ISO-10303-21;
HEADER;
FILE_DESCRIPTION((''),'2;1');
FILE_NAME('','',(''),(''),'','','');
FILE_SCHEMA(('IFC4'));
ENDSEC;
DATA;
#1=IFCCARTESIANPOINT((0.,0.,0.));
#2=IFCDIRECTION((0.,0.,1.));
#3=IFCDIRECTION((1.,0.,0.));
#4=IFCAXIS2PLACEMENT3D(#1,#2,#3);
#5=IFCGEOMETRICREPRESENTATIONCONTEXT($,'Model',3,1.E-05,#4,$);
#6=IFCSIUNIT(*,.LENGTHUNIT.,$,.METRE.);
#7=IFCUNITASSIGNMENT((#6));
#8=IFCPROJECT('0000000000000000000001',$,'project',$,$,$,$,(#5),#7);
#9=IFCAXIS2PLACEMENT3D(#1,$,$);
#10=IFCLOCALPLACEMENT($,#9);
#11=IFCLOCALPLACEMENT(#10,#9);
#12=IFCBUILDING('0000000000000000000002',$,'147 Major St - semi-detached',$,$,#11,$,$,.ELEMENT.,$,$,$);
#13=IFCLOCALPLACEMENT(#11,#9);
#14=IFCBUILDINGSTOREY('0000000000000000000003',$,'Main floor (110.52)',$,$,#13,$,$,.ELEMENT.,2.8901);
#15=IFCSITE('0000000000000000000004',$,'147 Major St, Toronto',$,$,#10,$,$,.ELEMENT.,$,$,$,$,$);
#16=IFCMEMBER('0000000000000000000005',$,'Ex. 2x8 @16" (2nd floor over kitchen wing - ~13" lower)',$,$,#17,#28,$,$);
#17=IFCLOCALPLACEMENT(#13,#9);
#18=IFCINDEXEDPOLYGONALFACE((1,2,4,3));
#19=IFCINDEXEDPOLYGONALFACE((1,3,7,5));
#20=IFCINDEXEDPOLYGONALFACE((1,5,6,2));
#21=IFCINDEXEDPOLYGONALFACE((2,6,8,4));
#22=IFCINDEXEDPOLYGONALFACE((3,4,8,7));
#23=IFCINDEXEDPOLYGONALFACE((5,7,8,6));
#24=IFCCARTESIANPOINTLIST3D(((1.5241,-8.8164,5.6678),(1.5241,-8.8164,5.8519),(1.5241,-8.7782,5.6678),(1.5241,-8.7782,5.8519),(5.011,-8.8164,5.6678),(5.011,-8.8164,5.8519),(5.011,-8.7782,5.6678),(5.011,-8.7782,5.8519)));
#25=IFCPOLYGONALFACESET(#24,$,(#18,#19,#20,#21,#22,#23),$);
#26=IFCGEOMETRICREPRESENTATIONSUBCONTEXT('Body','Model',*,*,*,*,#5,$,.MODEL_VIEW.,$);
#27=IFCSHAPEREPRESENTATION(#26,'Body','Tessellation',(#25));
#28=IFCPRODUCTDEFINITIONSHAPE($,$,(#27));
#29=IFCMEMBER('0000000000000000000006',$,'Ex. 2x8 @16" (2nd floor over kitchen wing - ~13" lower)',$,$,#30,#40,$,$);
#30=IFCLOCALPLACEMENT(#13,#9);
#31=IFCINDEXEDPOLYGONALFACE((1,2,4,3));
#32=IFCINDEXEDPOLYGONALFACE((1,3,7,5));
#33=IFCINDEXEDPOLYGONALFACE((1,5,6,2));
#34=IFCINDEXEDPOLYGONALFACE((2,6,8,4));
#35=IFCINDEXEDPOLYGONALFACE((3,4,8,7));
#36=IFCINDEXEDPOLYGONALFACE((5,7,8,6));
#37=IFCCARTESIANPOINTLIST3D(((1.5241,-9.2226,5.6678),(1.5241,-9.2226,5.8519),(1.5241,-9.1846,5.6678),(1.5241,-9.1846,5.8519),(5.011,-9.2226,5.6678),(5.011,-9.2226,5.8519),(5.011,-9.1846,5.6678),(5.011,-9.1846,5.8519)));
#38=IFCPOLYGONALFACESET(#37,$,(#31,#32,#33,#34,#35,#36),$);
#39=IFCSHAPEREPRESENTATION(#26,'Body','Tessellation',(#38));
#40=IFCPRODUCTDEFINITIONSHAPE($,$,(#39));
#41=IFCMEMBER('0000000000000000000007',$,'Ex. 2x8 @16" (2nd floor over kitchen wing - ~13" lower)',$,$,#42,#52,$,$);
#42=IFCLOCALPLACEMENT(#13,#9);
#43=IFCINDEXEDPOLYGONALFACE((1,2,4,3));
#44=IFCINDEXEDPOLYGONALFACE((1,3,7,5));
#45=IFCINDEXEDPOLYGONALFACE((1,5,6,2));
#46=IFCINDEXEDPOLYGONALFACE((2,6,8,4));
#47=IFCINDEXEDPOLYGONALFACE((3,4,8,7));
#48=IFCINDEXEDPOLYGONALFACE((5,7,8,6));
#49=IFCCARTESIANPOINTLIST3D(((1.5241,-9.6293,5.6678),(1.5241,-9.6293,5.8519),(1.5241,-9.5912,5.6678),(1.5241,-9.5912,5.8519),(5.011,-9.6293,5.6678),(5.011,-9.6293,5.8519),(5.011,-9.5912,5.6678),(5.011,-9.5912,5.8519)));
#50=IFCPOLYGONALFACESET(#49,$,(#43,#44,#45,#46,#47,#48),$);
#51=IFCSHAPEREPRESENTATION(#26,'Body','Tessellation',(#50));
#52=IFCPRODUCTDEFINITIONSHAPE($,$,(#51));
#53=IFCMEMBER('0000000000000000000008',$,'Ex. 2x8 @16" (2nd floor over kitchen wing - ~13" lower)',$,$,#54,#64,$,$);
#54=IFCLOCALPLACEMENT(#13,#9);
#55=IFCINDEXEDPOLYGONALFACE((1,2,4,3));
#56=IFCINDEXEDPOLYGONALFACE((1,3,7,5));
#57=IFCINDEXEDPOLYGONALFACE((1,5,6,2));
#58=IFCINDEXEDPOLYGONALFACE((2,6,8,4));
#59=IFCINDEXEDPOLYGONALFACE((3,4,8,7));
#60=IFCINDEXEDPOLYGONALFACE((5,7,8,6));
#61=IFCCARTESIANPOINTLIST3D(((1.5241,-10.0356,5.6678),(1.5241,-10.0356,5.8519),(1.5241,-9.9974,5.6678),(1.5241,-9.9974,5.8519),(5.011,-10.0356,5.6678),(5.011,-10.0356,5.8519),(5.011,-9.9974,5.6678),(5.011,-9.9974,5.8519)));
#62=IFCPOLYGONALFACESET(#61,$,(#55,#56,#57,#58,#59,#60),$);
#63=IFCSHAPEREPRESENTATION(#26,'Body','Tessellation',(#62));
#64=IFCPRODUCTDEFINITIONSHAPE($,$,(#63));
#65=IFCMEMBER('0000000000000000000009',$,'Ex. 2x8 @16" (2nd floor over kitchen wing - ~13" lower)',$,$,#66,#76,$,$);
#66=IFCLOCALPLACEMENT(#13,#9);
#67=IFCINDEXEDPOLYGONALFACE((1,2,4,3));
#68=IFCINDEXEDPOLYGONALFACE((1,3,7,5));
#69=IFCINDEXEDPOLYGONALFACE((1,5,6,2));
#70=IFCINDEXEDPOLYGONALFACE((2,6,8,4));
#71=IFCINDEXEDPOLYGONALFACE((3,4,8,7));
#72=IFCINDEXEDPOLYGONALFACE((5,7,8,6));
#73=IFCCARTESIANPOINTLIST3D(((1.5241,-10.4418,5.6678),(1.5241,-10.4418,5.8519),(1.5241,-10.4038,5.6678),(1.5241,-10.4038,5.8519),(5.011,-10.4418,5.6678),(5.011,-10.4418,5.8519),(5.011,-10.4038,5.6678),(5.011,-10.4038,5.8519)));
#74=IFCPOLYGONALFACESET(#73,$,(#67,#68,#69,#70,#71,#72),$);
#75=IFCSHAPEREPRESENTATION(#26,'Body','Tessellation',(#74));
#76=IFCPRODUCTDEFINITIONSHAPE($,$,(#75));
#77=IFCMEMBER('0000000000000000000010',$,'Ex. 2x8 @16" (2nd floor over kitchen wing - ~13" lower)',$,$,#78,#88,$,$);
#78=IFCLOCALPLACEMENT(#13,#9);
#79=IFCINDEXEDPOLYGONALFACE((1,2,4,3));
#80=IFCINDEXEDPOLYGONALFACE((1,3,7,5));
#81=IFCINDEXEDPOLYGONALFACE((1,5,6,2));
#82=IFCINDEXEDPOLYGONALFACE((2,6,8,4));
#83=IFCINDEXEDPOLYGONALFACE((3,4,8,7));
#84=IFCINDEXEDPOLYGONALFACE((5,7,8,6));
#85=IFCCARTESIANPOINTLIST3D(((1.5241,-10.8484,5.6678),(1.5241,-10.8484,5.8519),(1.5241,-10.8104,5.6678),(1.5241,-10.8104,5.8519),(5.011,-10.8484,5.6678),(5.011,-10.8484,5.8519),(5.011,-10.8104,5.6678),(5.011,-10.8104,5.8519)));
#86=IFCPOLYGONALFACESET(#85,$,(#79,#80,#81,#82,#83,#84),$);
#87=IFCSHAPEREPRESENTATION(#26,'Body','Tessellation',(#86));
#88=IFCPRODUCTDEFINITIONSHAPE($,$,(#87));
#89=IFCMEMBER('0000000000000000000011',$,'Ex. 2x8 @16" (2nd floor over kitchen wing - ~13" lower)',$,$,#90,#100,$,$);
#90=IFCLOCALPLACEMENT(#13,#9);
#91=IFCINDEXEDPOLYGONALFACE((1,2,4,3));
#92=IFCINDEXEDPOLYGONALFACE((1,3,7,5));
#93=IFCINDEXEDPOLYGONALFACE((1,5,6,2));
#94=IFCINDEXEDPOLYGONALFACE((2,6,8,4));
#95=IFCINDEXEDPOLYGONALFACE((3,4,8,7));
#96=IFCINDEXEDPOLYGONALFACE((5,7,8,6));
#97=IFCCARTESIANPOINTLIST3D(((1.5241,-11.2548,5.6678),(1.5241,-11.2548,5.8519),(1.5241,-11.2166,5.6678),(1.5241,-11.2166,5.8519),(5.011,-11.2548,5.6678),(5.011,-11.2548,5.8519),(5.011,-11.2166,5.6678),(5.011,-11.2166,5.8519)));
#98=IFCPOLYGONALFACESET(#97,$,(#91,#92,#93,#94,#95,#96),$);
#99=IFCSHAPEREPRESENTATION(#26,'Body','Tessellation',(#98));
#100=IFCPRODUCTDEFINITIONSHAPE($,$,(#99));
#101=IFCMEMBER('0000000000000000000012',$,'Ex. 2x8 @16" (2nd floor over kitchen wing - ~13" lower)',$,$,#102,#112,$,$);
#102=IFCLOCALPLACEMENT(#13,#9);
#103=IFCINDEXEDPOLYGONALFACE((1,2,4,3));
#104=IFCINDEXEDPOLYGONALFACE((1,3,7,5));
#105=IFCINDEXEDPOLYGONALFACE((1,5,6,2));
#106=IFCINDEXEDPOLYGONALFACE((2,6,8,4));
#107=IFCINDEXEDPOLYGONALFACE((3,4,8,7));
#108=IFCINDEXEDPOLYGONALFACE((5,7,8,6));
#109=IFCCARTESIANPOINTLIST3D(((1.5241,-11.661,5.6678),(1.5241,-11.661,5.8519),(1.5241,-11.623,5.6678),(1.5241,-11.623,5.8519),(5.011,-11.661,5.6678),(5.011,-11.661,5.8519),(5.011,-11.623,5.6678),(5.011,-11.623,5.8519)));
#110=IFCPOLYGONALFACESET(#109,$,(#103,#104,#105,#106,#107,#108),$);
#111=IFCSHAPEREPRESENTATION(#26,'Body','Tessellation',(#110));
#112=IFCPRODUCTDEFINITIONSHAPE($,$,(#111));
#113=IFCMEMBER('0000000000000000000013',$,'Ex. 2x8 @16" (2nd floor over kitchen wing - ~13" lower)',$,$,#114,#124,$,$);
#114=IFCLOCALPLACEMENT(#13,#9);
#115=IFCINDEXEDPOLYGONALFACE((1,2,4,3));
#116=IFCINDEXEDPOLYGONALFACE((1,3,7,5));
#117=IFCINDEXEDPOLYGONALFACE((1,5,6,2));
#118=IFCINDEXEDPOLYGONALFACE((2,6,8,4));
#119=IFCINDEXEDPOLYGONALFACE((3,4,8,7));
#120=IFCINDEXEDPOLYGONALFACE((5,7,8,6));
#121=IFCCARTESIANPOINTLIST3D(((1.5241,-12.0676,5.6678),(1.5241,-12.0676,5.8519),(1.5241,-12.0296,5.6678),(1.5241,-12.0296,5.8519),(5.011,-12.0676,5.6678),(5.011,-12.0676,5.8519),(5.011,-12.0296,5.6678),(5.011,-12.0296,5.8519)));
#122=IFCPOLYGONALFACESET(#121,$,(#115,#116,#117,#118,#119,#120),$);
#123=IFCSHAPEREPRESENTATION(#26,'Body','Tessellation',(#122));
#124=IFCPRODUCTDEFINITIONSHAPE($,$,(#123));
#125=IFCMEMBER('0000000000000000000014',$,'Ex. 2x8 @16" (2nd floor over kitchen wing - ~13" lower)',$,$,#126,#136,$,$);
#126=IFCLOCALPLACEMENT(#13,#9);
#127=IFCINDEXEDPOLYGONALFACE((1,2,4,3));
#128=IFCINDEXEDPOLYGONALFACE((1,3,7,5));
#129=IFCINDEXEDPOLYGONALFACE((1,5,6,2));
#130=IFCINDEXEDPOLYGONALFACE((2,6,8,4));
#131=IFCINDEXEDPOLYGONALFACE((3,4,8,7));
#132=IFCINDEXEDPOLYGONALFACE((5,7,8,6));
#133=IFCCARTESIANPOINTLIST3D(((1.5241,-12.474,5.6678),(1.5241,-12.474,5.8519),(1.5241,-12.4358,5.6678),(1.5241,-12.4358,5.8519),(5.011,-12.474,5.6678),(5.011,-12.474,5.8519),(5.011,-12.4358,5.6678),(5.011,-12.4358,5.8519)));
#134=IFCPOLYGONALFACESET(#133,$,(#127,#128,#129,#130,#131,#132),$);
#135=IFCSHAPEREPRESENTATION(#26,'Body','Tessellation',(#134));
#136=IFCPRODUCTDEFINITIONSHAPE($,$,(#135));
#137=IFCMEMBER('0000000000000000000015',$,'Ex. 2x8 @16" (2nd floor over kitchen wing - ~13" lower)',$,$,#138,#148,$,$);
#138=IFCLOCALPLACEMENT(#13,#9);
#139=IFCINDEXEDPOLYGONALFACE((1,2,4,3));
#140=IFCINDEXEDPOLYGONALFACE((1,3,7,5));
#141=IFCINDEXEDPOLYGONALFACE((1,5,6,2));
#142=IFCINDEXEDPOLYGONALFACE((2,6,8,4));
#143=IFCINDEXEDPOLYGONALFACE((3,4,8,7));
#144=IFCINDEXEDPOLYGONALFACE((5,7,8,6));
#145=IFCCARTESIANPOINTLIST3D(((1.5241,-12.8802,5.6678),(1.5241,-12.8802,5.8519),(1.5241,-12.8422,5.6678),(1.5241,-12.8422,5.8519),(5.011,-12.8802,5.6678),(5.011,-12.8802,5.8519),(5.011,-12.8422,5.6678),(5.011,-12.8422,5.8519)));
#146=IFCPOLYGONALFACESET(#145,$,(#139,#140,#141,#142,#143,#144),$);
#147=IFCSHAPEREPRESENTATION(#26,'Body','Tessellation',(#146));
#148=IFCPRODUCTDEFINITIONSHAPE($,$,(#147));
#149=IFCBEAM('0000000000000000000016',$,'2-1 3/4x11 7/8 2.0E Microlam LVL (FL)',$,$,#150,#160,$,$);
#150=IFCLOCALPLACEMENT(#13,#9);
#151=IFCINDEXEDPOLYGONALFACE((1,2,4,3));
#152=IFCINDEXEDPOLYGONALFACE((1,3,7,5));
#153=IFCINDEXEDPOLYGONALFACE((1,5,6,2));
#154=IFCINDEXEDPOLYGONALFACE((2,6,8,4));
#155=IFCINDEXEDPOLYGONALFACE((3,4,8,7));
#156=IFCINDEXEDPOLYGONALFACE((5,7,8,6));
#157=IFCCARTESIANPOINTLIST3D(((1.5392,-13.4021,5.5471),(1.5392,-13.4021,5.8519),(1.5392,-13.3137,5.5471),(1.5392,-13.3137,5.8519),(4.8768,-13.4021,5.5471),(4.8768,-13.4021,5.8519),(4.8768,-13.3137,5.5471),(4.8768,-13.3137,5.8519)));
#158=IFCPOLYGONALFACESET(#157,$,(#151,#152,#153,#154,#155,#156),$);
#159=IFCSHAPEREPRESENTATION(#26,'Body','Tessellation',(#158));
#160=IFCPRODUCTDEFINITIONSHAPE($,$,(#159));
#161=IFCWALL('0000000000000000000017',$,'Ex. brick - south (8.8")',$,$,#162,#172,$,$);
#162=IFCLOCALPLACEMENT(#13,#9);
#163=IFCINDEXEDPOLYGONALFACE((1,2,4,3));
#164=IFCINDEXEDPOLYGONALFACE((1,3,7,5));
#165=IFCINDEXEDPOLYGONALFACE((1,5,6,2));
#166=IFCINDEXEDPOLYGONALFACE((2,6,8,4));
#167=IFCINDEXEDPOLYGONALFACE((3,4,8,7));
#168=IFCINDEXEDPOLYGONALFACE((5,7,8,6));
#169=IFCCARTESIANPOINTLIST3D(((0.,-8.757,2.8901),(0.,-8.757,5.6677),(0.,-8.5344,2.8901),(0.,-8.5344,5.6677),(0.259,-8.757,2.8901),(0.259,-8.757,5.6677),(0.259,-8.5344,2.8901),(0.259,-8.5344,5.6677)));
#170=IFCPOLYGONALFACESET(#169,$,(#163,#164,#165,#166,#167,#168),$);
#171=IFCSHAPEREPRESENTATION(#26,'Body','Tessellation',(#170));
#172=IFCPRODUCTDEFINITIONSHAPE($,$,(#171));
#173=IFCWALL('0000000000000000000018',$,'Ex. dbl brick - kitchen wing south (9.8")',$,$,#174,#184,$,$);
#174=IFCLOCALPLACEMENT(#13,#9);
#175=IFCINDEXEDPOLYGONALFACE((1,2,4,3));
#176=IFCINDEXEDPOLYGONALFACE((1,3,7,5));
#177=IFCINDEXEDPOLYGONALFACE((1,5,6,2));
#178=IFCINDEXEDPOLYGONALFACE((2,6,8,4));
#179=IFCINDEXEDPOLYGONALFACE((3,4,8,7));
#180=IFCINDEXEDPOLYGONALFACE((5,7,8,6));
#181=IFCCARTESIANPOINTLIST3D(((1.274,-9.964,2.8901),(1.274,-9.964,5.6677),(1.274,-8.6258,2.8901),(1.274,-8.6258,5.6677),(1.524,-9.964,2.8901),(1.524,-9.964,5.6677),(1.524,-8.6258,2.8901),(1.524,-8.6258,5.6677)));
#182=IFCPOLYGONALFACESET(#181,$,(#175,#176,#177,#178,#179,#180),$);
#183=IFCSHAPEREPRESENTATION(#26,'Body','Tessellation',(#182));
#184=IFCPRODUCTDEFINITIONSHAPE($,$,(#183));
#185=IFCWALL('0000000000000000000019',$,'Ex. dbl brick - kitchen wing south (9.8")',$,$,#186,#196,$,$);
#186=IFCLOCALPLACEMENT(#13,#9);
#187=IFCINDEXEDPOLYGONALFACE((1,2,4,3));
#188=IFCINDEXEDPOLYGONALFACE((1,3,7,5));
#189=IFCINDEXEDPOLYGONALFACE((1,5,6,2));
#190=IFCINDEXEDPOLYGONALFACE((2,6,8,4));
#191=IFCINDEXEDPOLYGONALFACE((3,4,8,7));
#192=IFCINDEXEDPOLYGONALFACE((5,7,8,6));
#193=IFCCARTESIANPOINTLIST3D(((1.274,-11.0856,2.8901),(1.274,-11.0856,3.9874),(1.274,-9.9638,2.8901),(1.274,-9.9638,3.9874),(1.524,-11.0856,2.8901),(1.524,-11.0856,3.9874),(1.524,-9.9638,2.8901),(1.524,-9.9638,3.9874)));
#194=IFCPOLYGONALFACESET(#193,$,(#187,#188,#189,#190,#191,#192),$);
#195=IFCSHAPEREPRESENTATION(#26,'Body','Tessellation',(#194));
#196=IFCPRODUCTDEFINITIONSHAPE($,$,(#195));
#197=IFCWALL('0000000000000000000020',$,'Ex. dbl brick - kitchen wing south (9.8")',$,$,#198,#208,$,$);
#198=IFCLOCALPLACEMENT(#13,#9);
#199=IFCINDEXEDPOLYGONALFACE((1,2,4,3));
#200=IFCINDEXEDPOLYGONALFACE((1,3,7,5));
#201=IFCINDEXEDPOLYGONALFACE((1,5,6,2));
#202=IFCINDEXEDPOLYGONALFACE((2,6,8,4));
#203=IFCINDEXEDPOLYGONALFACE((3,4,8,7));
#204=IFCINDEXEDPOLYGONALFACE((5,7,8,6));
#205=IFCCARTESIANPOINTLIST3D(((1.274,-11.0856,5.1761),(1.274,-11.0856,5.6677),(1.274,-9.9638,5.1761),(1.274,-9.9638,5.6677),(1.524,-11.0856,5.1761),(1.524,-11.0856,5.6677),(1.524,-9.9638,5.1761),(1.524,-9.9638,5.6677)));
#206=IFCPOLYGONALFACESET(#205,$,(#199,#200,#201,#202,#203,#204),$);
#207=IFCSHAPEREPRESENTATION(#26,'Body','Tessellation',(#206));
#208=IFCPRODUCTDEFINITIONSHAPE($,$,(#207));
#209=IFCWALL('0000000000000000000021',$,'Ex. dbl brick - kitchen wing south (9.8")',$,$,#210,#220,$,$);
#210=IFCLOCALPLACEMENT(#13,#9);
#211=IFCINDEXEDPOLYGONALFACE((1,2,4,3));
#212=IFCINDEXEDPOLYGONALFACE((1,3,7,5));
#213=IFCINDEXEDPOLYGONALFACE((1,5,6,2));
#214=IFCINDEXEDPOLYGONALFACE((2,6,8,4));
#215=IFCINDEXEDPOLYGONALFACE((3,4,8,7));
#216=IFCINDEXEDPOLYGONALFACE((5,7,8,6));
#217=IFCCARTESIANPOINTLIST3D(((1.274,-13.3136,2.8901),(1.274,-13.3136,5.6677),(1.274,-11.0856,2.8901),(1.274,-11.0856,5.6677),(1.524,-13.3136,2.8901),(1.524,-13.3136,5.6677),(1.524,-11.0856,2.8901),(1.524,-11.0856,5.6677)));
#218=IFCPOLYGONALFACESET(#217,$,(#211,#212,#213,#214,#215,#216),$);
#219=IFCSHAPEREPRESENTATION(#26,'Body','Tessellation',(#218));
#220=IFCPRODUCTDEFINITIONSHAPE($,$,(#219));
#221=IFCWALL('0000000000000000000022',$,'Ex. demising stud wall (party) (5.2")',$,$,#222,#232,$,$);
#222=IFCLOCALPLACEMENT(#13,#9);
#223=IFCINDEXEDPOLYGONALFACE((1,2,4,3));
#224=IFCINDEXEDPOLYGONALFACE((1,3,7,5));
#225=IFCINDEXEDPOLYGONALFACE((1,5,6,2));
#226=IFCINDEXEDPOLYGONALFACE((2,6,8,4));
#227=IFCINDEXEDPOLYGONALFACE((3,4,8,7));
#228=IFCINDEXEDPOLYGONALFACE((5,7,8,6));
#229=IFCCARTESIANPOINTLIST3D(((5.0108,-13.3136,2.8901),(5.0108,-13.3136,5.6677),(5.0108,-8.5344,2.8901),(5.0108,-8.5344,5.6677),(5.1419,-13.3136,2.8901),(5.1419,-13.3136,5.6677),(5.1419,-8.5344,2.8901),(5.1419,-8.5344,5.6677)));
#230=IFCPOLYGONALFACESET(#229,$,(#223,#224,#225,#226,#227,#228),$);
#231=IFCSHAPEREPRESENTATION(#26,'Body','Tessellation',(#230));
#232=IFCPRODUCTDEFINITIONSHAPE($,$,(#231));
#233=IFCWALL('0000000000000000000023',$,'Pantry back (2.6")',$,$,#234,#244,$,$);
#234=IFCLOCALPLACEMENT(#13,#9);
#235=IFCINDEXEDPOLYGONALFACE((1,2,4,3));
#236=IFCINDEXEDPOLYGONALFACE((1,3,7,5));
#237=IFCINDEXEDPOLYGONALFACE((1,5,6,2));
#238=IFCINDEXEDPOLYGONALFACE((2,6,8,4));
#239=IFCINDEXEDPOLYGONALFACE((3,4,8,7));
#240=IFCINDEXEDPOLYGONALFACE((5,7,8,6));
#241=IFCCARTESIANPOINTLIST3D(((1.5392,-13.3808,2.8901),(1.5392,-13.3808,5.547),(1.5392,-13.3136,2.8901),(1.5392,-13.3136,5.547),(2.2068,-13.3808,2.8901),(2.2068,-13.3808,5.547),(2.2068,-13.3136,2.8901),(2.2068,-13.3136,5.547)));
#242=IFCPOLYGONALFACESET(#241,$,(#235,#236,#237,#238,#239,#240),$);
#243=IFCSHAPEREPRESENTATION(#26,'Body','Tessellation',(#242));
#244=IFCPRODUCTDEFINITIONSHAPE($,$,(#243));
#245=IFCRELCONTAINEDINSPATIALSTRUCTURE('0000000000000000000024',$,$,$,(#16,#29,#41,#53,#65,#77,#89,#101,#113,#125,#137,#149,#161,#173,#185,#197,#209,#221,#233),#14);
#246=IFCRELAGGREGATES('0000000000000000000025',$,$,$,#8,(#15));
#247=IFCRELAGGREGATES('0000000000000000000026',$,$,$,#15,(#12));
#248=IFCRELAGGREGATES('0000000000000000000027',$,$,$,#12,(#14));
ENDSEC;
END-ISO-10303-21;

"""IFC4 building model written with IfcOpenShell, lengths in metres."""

from ifc_helpers import new_model, si_unit, frame, origin, origin_with_axes, place, context, subcontext, project, spatial, rectangle, extrude, element, save


model = new_model("IFC4")

# Units and contexts
model_context = context("Model", 3, precision=1e-05, world=origin_with_axes())
body_context = subcontext(model_context, "Body", "Model", "MODEL_VIEW")
ifc_project = project(units=[si_unit("LENGTHUNIT", "METRE")], contexts=[model_context])

# Site, building, storey
site_placement = place(None, origin())
site = spatial("IfcSite", under=ifc_project, at=site_placement, Name="147 Major St, Toronto", CompositionType="ELEMENT")
building_placement = place(site_placement, origin())
building = spatial("IfcBuilding", under=site, at=building_placement, Name="147 Major St - semi-detached", CompositionType="ELEMENT")
storey_placement = place(building_placement, origin())
storey = spatial("IfcBuildingStorey", under=building, at=storey_placement, Name="Main floor (110.52)", CompositionType="ELEMENT", Elevation=2.8901)

# Members
for number, where, name in (
    (1, (3.2675, -8.7973, 5.6678), "Ex. 2x8 @16\" (2nd floor over kitchen wing - ~13\" lower)"),
    (2, (3.2675, -9.2036, 5.6678), "Ex. 2x8 @16\" (2nd floor over kitchen wing - ~13\" lower)"),
    (3, (3.2675, -9.6102, 5.6678), "Ex. 2x8 @16\" (2nd floor over kitchen wing - ~13\" lower)"),
    (4, (3.2675, -10.0165, 5.6678), "Ex. 2x8 @16\" (2nd floor over kitchen wing - ~13\" lower)"),
    (5, (3.2675, -10.4228, 5.6678), "Ex. 2x8 @16\" (2nd floor over kitchen wing - ~13\" lower)"),
    (6, (3.2675, -10.8294, 5.6678), "Ex. 2x8 @16\" (2nd floor over kitchen wing - ~13\" lower)"),
    (7, (3.2675, -11.2357, 5.6678), "Ex. 2x8 @16\" (2nd floor over kitchen wing - ~13\" lower)"),
    (8, (3.2675, -11.642, 5.6678), "Ex. 2x8 @16\" (2nd floor over kitchen wing - ~13\" lower)"),
    (9, (3.2675, -12.0486, 5.6678), "Ex. 2x8 @16\" (2nd floor over kitchen wing - ~13\" lower)"),
    (10, (3.2675, -12.4549, 5.6678), "Ex. 2x8 @16\" (2nd floor over kitchen wing - ~13\" lower)"),
    (11, (3.2675, -12.8612, 5.6678), "Ex. 2x8 @16\" (2nd floor over kitchen wing - ~13\" lower)"),
):
    element("IfcMember", number, at=place(storey_placement, frame(where)), inside=storey, Name=name, context=body_context, shape_type="SweptSolid", body=[
        extrude(rectangle(XDim=3.4869, YDim=0.0381), origin_with_axes(), (0.0, 0.0, 1.0), 0.1841),
    ])

# Beam
beam_placement = place(storey_placement, frame((3.208, -13.3579, 5.5471)))
element("IfcBeam", 12, at=beam_placement, inside=storey, Name="2-1 3/4x11 7/8 2.0E Microlam LVL (FL)", context=body_context, shape_type="SweptSolid", body=[
    extrude(rectangle(XDim=3.3376, YDim=0.0884), origin_with_axes(), (0.0, 0.0, 1.0), 0.3048),
])

# Walls
wall_1_placement = place(storey_placement, frame((0.1295, -8.6457, 2.8901)))
element("IfcWall", 13, at=wall_1_placement, inside=storey, Name="Ex. brick - south (8.8\")", context=body_context, shape_type="SweptSolid", body=[
    extrude(rectangle(XDim=0.2591, YDim=0.2225), origin_with_axes(), (0.0, 0.0, 1.0), 2.7776),
])
wall_2_placement = place(storey_placement, frame((1.399, -9.2949, 2.8901)))
element("IfcWall", 14, at=wall_2_placement, inside=storey, Name="Ex. dbl brick - kitchen wing south (9.8\")", context=body_context, shape_type="SweptSolid", body=[
    extrude(rectangle(XDim=0.2499, YDim=1.3381), origin_with_axes(), (0.0, 0.0, 1.0), 2.7776),
])
wall_3_placement = place(storey_placement, frame((1.399, -10.5247, 2.8901)))
element("IfcWall", 15, at=wall_3_placement, inside=storey, Name="Ex. dbl brick - kitchen wing south (9.8\")", context=body_context, shape_type="SweptSolid", body=[
    extrude(rectangle(XDim=0.2499, YDim=1.1217), origin_with_axes(), (0.0, 0.0, 1.0), 1.0973),
])
wall_4_placement = place(storey_placement, frame((1.399, -10.5247, 5.1761)))
element("IfcWall", 16, at=wall_4_placement, inside=storey, Name="Ex. dbl brick - kitchen wing south (9.8\")", context=body_context, shape_type="SweptSolid", body=[
    extrude(rectangle(XDim=0.2499, YDim=1.1217), origin_with_axes(), (0.0, 0.0, 1.0), 0.4916),
])
wall_5_placement = place(storey_placement, frame((1.399, -12.1996, 2.8901)))
element("IfcWall", 17, at=wall_5_placement, inside=storey, Name="Ex. dbl brick - kitchen wing south (9.8\")", context=body_context, shape_type="SweptSolid", body=[
    extrude(rectangle(XDim=0.2499, YDim=2.2281), origin_with_axes(), (0.0, 0.0, 1.0), 2.7776),
])
wall_6_placement = place(storey_placement, frame((5.0764, -10.924, 2.8901)))
element("IfcWall", 18, at=wall_6_placement, inside=storey, Name="Ex. demising stud wall (party) (5.2\")", context=body_context, shape_type="SweptSolid", body=[
    extrude(rectangle(XDim=0.1311, YDim=4.7793), origin_with_axes(), (0.0, 0.0, 1.0), 2.7776),
])
wall_7_placement = place(storey_placement, frame((1.873, -13.3472, 2.8901)))
element("IfcWall", 19, at=wall_7_placement, inside=storey, Name="Pantry back (2.6\")", context=body_context, shape_type="SweptSolid", body=[
    extrude(rectangle(XDim=0.6675, YDim=0.0671), origin_with_axes(), (0.0, 0.0, 1.0), 2.6569),
])

save(model, "model.ifc")
